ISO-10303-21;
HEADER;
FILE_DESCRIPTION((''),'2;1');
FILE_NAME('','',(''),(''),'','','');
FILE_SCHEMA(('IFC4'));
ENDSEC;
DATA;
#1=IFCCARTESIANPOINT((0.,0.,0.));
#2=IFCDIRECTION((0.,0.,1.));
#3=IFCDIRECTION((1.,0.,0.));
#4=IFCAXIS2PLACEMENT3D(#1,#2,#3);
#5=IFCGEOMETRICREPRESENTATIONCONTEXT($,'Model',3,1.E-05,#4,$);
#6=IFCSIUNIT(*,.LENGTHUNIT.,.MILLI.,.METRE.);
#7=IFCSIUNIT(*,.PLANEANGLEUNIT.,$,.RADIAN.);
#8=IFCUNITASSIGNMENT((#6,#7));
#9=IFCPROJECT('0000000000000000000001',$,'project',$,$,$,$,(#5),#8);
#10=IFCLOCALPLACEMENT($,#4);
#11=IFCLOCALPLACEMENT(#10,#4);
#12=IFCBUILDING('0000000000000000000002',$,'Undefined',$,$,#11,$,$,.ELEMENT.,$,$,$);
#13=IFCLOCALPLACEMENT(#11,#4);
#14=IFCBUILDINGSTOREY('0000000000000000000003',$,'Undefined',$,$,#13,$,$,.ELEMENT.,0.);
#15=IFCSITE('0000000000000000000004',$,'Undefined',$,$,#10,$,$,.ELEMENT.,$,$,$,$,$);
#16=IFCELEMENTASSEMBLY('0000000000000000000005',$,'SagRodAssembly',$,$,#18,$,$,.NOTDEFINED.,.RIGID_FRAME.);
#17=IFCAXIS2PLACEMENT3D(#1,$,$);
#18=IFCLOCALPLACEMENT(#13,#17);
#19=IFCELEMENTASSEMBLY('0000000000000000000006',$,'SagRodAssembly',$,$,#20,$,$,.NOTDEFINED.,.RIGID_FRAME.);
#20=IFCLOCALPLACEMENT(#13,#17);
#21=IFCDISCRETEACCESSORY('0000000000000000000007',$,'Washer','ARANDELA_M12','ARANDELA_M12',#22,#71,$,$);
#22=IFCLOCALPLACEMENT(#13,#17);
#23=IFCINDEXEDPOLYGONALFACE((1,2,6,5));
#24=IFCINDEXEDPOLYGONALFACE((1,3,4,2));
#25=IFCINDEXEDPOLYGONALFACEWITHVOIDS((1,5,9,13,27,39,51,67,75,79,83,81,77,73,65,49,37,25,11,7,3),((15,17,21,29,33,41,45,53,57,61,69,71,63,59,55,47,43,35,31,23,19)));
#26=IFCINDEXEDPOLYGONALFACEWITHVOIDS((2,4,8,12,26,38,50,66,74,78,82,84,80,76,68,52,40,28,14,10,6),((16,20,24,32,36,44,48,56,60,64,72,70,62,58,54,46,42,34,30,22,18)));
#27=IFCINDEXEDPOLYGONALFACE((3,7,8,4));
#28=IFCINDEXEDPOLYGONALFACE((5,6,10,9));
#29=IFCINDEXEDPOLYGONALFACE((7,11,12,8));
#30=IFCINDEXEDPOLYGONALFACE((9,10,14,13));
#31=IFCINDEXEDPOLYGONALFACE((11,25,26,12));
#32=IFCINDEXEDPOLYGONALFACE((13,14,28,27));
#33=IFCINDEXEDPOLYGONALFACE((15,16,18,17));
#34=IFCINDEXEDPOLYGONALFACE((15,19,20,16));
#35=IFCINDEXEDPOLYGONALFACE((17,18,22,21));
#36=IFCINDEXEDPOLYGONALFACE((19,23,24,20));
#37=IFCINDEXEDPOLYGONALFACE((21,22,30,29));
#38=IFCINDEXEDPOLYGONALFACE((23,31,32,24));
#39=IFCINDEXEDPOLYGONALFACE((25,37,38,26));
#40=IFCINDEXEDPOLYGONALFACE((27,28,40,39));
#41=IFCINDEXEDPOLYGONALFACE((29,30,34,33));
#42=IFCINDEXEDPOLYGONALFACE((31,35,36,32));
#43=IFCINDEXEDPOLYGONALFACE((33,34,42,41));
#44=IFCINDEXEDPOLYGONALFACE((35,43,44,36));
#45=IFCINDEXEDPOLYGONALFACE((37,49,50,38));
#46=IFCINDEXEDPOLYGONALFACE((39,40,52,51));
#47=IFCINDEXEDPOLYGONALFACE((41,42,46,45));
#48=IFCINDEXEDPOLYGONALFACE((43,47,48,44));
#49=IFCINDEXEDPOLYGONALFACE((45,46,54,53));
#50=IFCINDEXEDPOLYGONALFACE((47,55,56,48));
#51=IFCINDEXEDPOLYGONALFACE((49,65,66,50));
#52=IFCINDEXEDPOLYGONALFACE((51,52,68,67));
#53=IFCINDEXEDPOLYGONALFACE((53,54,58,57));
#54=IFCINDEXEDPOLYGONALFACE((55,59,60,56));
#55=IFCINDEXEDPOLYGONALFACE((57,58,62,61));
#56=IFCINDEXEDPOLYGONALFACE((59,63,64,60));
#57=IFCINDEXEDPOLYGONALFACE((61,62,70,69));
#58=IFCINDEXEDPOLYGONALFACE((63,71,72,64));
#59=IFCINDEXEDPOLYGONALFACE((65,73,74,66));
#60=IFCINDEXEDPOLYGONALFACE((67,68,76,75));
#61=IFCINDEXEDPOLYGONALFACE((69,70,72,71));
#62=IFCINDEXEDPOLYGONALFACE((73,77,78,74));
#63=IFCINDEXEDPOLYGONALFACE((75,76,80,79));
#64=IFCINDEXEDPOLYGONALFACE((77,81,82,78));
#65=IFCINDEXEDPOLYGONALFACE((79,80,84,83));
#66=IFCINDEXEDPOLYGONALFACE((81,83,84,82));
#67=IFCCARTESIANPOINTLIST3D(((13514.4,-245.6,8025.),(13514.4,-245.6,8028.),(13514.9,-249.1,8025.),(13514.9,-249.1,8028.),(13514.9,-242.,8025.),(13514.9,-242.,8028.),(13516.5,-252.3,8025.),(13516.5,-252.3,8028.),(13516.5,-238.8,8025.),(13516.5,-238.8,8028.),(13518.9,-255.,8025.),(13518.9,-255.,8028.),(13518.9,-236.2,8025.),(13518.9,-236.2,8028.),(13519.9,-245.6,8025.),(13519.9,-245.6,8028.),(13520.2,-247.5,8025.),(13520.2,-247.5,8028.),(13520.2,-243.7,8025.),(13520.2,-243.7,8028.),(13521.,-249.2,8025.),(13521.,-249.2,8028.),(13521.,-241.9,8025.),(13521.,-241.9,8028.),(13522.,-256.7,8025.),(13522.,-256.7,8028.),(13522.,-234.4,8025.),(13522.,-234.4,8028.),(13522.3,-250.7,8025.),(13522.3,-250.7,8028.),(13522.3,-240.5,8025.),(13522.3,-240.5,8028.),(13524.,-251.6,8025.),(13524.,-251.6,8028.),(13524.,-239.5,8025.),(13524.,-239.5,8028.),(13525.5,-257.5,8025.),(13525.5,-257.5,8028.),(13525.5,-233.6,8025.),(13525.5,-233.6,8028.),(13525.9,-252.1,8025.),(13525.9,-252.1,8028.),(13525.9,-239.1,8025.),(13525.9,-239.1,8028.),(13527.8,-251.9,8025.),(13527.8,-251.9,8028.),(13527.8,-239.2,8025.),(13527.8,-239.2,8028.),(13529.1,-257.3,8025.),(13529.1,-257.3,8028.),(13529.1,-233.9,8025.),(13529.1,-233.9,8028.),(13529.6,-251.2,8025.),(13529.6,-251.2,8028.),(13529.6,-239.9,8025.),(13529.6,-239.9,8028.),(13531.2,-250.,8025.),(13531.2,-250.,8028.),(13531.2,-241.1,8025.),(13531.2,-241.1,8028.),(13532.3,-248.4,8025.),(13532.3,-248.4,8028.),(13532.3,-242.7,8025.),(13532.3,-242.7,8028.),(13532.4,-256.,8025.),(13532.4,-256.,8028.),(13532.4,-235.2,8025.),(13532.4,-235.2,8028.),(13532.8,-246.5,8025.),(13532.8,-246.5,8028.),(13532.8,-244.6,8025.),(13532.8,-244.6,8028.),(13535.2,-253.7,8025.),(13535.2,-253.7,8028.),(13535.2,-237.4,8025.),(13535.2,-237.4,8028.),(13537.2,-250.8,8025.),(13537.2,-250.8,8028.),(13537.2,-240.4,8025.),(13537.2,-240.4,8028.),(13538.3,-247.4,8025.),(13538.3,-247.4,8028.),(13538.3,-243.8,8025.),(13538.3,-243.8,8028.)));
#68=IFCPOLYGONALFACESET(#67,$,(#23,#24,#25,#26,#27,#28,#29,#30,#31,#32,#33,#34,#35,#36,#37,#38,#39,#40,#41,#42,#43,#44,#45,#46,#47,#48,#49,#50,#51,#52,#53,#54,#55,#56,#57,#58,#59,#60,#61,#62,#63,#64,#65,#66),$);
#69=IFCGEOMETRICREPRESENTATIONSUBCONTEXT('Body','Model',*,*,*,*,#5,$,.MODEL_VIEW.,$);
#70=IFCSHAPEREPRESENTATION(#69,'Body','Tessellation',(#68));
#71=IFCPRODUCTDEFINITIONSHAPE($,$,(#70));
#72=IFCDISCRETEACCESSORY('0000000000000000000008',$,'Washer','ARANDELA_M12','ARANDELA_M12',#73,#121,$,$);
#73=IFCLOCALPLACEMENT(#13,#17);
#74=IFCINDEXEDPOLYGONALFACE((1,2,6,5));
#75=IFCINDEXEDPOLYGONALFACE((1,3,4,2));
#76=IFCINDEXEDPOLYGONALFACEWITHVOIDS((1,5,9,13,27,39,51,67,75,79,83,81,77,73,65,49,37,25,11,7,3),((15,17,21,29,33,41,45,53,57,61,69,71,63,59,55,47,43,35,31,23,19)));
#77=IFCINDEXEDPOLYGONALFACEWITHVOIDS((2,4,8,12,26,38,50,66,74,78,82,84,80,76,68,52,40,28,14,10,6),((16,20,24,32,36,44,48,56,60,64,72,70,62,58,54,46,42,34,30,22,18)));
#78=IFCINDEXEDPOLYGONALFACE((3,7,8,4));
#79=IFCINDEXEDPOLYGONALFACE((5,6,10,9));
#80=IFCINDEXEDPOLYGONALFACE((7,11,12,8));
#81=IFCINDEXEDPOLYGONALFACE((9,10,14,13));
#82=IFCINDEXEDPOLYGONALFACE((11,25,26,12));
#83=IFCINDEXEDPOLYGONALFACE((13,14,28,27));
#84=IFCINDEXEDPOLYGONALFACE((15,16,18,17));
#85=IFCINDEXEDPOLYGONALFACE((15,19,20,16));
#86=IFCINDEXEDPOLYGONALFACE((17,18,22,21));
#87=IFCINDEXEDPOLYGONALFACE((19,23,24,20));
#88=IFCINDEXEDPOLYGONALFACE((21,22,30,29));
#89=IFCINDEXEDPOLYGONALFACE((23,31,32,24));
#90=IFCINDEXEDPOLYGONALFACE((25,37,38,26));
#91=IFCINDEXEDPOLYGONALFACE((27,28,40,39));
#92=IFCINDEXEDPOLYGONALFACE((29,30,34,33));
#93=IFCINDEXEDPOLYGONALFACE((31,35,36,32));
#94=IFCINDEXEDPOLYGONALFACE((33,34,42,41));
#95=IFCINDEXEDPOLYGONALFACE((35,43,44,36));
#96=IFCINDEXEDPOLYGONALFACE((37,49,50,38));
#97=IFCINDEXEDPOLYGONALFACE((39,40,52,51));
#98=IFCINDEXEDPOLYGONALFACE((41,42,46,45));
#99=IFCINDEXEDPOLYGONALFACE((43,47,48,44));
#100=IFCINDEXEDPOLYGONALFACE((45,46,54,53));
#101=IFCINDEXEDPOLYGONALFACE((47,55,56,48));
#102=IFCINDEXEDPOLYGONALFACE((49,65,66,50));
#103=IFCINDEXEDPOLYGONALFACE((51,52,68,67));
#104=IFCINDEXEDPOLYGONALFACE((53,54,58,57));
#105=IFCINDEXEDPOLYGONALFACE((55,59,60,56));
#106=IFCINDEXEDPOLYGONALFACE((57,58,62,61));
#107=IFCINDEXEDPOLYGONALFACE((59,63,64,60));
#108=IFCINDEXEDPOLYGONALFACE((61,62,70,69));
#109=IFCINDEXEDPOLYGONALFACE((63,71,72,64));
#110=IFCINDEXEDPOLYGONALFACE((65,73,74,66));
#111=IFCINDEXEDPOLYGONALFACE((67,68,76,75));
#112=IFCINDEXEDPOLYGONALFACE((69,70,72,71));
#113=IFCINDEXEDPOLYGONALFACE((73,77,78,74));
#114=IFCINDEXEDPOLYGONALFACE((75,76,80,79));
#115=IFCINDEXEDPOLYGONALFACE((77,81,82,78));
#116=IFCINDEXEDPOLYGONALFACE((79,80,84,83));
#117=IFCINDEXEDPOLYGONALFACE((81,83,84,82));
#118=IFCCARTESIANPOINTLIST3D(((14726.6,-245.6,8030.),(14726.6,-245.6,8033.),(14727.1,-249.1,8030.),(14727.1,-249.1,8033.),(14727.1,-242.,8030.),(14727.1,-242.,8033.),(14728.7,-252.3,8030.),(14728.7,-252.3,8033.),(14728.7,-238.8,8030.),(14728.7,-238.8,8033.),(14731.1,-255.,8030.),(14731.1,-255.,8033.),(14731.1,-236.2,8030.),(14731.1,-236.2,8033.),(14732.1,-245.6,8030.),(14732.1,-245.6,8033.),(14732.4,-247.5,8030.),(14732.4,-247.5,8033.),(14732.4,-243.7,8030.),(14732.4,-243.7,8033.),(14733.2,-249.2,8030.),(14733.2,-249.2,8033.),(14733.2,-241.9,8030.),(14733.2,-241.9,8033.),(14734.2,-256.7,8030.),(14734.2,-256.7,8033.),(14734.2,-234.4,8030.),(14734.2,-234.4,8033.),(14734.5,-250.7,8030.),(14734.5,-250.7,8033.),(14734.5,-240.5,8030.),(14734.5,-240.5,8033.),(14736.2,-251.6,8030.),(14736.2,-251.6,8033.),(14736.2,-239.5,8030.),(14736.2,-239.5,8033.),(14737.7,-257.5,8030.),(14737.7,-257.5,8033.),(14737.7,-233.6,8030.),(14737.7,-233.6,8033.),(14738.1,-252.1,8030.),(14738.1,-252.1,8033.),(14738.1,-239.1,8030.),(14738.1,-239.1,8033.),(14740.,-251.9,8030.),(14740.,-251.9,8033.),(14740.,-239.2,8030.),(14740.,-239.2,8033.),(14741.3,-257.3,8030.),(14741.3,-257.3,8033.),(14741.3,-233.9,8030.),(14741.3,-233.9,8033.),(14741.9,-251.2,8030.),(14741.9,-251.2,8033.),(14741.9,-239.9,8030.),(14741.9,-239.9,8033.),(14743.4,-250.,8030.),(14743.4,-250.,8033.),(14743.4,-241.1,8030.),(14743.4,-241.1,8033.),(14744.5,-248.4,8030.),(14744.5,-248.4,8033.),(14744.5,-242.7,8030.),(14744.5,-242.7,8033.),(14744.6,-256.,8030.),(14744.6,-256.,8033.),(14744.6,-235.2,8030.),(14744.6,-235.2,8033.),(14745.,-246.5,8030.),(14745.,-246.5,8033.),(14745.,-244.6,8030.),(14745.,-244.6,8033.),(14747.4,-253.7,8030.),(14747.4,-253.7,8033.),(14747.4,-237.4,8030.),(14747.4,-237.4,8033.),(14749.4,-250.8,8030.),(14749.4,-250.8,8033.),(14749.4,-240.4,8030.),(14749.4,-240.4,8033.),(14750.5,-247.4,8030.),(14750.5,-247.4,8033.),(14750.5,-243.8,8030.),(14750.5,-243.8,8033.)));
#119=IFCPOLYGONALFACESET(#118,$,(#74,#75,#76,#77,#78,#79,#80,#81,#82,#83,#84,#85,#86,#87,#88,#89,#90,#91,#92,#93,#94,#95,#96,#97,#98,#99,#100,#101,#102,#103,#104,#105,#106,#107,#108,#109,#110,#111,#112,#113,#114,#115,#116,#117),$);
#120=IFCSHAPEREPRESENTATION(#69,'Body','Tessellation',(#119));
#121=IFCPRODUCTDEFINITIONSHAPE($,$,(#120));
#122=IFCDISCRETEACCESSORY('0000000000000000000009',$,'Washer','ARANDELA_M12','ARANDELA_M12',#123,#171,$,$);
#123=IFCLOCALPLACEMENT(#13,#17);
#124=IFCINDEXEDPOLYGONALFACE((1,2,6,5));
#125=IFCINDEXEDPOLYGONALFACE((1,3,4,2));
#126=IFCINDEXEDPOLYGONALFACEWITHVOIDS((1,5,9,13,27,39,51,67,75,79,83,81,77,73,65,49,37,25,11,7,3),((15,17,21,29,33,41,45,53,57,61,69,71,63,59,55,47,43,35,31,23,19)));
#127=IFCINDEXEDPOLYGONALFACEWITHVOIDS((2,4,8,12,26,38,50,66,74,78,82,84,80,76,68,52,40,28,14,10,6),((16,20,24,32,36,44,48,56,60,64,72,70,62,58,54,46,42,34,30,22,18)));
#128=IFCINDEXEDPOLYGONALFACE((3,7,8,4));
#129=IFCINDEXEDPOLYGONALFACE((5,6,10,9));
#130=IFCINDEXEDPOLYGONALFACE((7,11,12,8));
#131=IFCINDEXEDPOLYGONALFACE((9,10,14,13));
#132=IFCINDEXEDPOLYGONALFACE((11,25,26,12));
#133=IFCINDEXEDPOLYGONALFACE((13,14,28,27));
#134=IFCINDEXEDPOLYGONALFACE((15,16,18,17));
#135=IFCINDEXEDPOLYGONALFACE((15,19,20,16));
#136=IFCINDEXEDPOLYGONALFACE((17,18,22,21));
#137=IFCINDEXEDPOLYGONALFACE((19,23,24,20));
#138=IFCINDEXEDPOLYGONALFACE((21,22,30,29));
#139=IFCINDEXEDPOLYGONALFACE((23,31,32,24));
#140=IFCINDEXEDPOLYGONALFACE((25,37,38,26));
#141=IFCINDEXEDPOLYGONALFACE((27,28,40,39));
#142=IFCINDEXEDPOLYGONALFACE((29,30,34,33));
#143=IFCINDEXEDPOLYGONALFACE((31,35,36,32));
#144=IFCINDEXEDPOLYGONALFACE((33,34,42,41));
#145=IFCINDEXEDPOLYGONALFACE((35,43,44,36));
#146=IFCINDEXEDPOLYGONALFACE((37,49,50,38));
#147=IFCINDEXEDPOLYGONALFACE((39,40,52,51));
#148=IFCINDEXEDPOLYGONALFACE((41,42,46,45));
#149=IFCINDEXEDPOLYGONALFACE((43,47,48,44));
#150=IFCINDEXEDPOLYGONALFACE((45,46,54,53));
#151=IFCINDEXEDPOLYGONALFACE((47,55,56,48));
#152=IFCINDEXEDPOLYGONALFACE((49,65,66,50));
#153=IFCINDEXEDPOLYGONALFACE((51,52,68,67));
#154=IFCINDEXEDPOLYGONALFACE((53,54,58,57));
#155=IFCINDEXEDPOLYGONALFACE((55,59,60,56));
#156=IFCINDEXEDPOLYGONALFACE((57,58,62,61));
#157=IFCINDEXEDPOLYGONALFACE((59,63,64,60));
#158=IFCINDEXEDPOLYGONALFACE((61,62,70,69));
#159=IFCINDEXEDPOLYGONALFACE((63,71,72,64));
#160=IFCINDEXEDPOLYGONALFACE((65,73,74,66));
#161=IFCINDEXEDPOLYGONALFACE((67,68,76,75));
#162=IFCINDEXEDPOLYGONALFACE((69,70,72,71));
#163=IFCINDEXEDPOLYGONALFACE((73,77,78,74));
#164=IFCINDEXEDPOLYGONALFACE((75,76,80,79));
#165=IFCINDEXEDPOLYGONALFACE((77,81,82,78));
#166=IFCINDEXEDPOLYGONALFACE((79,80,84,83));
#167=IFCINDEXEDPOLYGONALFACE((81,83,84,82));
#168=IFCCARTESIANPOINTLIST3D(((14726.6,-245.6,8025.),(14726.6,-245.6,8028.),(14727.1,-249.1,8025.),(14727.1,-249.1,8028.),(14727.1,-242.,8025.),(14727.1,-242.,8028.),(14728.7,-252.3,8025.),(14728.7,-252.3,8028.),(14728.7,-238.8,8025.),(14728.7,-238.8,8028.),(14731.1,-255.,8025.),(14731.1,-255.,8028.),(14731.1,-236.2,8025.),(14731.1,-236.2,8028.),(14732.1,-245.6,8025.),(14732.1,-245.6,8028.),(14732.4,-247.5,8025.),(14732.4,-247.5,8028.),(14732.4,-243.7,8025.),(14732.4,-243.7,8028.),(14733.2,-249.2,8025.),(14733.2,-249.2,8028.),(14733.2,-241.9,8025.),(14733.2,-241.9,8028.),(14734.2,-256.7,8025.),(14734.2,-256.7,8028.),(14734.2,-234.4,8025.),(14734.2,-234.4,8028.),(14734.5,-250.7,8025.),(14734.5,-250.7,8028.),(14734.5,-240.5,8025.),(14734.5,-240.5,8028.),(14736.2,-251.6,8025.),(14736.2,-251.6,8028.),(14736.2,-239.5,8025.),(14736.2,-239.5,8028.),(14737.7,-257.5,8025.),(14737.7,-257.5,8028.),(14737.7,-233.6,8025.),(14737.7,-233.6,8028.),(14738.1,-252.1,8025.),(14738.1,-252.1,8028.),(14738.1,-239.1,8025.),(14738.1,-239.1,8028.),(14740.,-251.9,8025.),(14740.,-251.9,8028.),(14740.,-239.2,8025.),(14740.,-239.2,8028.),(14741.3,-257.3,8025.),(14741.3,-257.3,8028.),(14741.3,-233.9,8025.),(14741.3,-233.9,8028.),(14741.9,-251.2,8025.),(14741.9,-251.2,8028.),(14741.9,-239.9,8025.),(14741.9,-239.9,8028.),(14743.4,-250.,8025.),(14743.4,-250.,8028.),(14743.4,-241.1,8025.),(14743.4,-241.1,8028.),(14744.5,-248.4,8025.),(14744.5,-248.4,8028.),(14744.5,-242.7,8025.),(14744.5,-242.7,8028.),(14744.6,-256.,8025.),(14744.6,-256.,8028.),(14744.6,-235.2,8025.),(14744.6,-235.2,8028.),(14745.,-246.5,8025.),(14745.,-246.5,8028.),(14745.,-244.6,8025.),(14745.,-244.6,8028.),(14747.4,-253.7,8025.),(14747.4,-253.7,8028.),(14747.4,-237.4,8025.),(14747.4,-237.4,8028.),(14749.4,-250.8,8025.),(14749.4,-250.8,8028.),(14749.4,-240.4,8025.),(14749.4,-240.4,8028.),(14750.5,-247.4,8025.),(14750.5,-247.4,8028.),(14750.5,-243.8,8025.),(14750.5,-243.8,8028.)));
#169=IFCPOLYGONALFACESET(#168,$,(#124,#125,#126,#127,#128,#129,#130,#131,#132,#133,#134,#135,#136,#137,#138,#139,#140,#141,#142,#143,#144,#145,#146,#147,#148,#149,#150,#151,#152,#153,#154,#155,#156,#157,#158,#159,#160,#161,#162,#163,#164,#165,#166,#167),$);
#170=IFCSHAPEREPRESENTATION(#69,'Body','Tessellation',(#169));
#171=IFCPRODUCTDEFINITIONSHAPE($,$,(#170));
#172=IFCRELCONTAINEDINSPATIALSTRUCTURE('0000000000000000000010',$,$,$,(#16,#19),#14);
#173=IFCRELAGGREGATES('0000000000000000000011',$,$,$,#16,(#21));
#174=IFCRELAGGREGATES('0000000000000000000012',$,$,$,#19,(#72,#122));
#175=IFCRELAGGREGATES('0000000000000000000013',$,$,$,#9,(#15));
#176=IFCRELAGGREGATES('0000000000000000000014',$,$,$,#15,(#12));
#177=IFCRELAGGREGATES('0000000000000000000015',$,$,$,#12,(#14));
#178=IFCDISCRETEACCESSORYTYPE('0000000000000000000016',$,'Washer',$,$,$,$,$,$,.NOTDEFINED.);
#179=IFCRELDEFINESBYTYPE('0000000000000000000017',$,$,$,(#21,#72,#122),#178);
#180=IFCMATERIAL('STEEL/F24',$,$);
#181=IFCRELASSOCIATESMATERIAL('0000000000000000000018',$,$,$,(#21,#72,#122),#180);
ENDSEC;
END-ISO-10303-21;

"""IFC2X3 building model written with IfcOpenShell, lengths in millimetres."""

from ifc_helpers import new_model, si_unit, frame, origin_with_axes, origin_2d_with_axis, place, context, subcontext, project, spatial, hollow_circle, extrude, material, type_object, element, aggregate, save


model = new_model("IFC2X3")

# Units and contexts
model_context = context("Model", 3, precision=1e-05, world=origin_with_axes())
body_context = subcontext(model_context, "Body", "Model", "MODEL_VIEW")
ifc_project = project(units=[si_unit("LENGTHUNIT", "METRE", prefix="MILLI"), si_unit("PLANEANGLEUNIT", "RADIAN")], contexts=[model_context])

# Site, building, storey
site_placement = place(None, origin_with_axes())
site = spatial("IfcSite", under=ifc_project, at=site_placement, Name="Undefined", CompositionType="ELEMENT")
building_placement = place(site_placement, origin_with_axes())
building = spatial("IfcBuilding", under=site, at=building_placement, Name="Undefined", CompositionType="ELEMENT")
storey_placement = place(building_placement, origin_with_axes())
storey = spatial("IfcBuildingStorey", under=building, at=storey_placement, Name="Undefined", CompositionType="ELEMENT", Elevation=0.0)

# Shared definitions
ifc_material_1 = material(Name="STEEL/F24")

# Element assemblies
assembly_1_placement = place(storey_placement, origin_with_axes())
assembly_1 = element("IfcElementAssembly", 1, at=assembly_1_placement, inside=storey, Name="SagRodAssembly", AssemblyPlace="NOTDEFINED", PredefinedType="RIGID_FRAME")
assembly_2_placement = place(storey_placement, origin_with_axes())
assembly_2 = element("IfcElementAssembly", 2, at=assembly_2_placement, inside=storey, Name="SagRodAssembly", AssemblyPlace="NOTDEFINED", PredefinedType="RIGID_FRAME")

# Discrete accessories
discrete_accessory_type_1 = type_object("IfcDiscreteAccessoryType", Name="Washer")
discrete_accessory_1_placement = place(assembly_1_placement, frame((13526.4, -245.6, 8025.0), z_axis=(0.0, 0.0, 1.0), x_axis=(0.0, 1.0, 0.0)))
discrete_accessory_1 = element("IfcDiscreteAccessory", 3, at=discrete_accessory_1_placement, type_object=discrete_accessory_type_1, material=ifc_material_1, Name="Washer", Description="ARANDELA_M12", ObjectType="ARANDELA_M12", context=body_context, shape_type="SweptSolid", body=[
    extrude(hollow_circle(Radius=12.0, WallThickness=5.5, at=origin_2d_with_axis()), frame((0.0, 0.0, 3.0), z_axis=(0.0, 0.0, -1.0), x_axis=(0.0, 1.0, 0.0)), (0.0, 0.0, 1.0), 3.0),
])
aggregate(assembly_1, [discrete_accessory_1])
discrete_accessory_2_placement = place(assembly_2_placement, frame((14738.6, -245.6, 8030.0), z_axis=(0.0, 0.0, 1.0), x_axis=(0.0, 1.0, 0.0)))
discrete_accessory_2 = element("IfcDiscreteAccessory", 4, at=discrete_accessory_2_placement, type_object=discrete_accessory_type_1, material=ifc_material_1, Name="Washer", Description="ARANDELA_M12", ObjectType="ARANDELA_M12", context=body_context, shape_type="SweptSolid", body=[
    extrude(hollow_circle(Radius=12.0, WallThickness=5.5, at=origin_2d_with_axis()), frame((0.0, 0.0, 3.0), z_axis=(0.0, 0.0, -1.0), x_axis=(0.0, 1.0, 0.0)), (0.0, 0.0, 1.0), 3.0),
])
discrete_accessory_3_placement = place(assembly_2_placement, frame((14738.6, -245.6, 8025.0), z_axis=(0.0, 0.0, 1.0), x_axis=(0.0, 1.0, 0.0)))
discrete_accessory_3 = element("IfcDiscreteAccessory", 5, at=discrete_accessory_3_placement, type_object=discrete_accessory_type_1, material=ifc_material_1, Name="Washer", Description="ARANDELA_M12", ObjectType="ARANDELA_M12", context=body_context, shape_type="SweptSolid", body=[
    extrude(hollow_circle(Radius=12.0, WallThickness=5.5, at=origin_2d_with_axis()), frame((0.0, 0.0, 3.0), z_axis=(0.0, 0.0, -1.0), x_axis=(0.0, 1.0, 0.0)), (0.0, 0.0, 1.0), 3.0),
])
aggregate(assembly_2, [discrete_accessory_2, discrete_accessory_3])

save(model, "model.ifc")
